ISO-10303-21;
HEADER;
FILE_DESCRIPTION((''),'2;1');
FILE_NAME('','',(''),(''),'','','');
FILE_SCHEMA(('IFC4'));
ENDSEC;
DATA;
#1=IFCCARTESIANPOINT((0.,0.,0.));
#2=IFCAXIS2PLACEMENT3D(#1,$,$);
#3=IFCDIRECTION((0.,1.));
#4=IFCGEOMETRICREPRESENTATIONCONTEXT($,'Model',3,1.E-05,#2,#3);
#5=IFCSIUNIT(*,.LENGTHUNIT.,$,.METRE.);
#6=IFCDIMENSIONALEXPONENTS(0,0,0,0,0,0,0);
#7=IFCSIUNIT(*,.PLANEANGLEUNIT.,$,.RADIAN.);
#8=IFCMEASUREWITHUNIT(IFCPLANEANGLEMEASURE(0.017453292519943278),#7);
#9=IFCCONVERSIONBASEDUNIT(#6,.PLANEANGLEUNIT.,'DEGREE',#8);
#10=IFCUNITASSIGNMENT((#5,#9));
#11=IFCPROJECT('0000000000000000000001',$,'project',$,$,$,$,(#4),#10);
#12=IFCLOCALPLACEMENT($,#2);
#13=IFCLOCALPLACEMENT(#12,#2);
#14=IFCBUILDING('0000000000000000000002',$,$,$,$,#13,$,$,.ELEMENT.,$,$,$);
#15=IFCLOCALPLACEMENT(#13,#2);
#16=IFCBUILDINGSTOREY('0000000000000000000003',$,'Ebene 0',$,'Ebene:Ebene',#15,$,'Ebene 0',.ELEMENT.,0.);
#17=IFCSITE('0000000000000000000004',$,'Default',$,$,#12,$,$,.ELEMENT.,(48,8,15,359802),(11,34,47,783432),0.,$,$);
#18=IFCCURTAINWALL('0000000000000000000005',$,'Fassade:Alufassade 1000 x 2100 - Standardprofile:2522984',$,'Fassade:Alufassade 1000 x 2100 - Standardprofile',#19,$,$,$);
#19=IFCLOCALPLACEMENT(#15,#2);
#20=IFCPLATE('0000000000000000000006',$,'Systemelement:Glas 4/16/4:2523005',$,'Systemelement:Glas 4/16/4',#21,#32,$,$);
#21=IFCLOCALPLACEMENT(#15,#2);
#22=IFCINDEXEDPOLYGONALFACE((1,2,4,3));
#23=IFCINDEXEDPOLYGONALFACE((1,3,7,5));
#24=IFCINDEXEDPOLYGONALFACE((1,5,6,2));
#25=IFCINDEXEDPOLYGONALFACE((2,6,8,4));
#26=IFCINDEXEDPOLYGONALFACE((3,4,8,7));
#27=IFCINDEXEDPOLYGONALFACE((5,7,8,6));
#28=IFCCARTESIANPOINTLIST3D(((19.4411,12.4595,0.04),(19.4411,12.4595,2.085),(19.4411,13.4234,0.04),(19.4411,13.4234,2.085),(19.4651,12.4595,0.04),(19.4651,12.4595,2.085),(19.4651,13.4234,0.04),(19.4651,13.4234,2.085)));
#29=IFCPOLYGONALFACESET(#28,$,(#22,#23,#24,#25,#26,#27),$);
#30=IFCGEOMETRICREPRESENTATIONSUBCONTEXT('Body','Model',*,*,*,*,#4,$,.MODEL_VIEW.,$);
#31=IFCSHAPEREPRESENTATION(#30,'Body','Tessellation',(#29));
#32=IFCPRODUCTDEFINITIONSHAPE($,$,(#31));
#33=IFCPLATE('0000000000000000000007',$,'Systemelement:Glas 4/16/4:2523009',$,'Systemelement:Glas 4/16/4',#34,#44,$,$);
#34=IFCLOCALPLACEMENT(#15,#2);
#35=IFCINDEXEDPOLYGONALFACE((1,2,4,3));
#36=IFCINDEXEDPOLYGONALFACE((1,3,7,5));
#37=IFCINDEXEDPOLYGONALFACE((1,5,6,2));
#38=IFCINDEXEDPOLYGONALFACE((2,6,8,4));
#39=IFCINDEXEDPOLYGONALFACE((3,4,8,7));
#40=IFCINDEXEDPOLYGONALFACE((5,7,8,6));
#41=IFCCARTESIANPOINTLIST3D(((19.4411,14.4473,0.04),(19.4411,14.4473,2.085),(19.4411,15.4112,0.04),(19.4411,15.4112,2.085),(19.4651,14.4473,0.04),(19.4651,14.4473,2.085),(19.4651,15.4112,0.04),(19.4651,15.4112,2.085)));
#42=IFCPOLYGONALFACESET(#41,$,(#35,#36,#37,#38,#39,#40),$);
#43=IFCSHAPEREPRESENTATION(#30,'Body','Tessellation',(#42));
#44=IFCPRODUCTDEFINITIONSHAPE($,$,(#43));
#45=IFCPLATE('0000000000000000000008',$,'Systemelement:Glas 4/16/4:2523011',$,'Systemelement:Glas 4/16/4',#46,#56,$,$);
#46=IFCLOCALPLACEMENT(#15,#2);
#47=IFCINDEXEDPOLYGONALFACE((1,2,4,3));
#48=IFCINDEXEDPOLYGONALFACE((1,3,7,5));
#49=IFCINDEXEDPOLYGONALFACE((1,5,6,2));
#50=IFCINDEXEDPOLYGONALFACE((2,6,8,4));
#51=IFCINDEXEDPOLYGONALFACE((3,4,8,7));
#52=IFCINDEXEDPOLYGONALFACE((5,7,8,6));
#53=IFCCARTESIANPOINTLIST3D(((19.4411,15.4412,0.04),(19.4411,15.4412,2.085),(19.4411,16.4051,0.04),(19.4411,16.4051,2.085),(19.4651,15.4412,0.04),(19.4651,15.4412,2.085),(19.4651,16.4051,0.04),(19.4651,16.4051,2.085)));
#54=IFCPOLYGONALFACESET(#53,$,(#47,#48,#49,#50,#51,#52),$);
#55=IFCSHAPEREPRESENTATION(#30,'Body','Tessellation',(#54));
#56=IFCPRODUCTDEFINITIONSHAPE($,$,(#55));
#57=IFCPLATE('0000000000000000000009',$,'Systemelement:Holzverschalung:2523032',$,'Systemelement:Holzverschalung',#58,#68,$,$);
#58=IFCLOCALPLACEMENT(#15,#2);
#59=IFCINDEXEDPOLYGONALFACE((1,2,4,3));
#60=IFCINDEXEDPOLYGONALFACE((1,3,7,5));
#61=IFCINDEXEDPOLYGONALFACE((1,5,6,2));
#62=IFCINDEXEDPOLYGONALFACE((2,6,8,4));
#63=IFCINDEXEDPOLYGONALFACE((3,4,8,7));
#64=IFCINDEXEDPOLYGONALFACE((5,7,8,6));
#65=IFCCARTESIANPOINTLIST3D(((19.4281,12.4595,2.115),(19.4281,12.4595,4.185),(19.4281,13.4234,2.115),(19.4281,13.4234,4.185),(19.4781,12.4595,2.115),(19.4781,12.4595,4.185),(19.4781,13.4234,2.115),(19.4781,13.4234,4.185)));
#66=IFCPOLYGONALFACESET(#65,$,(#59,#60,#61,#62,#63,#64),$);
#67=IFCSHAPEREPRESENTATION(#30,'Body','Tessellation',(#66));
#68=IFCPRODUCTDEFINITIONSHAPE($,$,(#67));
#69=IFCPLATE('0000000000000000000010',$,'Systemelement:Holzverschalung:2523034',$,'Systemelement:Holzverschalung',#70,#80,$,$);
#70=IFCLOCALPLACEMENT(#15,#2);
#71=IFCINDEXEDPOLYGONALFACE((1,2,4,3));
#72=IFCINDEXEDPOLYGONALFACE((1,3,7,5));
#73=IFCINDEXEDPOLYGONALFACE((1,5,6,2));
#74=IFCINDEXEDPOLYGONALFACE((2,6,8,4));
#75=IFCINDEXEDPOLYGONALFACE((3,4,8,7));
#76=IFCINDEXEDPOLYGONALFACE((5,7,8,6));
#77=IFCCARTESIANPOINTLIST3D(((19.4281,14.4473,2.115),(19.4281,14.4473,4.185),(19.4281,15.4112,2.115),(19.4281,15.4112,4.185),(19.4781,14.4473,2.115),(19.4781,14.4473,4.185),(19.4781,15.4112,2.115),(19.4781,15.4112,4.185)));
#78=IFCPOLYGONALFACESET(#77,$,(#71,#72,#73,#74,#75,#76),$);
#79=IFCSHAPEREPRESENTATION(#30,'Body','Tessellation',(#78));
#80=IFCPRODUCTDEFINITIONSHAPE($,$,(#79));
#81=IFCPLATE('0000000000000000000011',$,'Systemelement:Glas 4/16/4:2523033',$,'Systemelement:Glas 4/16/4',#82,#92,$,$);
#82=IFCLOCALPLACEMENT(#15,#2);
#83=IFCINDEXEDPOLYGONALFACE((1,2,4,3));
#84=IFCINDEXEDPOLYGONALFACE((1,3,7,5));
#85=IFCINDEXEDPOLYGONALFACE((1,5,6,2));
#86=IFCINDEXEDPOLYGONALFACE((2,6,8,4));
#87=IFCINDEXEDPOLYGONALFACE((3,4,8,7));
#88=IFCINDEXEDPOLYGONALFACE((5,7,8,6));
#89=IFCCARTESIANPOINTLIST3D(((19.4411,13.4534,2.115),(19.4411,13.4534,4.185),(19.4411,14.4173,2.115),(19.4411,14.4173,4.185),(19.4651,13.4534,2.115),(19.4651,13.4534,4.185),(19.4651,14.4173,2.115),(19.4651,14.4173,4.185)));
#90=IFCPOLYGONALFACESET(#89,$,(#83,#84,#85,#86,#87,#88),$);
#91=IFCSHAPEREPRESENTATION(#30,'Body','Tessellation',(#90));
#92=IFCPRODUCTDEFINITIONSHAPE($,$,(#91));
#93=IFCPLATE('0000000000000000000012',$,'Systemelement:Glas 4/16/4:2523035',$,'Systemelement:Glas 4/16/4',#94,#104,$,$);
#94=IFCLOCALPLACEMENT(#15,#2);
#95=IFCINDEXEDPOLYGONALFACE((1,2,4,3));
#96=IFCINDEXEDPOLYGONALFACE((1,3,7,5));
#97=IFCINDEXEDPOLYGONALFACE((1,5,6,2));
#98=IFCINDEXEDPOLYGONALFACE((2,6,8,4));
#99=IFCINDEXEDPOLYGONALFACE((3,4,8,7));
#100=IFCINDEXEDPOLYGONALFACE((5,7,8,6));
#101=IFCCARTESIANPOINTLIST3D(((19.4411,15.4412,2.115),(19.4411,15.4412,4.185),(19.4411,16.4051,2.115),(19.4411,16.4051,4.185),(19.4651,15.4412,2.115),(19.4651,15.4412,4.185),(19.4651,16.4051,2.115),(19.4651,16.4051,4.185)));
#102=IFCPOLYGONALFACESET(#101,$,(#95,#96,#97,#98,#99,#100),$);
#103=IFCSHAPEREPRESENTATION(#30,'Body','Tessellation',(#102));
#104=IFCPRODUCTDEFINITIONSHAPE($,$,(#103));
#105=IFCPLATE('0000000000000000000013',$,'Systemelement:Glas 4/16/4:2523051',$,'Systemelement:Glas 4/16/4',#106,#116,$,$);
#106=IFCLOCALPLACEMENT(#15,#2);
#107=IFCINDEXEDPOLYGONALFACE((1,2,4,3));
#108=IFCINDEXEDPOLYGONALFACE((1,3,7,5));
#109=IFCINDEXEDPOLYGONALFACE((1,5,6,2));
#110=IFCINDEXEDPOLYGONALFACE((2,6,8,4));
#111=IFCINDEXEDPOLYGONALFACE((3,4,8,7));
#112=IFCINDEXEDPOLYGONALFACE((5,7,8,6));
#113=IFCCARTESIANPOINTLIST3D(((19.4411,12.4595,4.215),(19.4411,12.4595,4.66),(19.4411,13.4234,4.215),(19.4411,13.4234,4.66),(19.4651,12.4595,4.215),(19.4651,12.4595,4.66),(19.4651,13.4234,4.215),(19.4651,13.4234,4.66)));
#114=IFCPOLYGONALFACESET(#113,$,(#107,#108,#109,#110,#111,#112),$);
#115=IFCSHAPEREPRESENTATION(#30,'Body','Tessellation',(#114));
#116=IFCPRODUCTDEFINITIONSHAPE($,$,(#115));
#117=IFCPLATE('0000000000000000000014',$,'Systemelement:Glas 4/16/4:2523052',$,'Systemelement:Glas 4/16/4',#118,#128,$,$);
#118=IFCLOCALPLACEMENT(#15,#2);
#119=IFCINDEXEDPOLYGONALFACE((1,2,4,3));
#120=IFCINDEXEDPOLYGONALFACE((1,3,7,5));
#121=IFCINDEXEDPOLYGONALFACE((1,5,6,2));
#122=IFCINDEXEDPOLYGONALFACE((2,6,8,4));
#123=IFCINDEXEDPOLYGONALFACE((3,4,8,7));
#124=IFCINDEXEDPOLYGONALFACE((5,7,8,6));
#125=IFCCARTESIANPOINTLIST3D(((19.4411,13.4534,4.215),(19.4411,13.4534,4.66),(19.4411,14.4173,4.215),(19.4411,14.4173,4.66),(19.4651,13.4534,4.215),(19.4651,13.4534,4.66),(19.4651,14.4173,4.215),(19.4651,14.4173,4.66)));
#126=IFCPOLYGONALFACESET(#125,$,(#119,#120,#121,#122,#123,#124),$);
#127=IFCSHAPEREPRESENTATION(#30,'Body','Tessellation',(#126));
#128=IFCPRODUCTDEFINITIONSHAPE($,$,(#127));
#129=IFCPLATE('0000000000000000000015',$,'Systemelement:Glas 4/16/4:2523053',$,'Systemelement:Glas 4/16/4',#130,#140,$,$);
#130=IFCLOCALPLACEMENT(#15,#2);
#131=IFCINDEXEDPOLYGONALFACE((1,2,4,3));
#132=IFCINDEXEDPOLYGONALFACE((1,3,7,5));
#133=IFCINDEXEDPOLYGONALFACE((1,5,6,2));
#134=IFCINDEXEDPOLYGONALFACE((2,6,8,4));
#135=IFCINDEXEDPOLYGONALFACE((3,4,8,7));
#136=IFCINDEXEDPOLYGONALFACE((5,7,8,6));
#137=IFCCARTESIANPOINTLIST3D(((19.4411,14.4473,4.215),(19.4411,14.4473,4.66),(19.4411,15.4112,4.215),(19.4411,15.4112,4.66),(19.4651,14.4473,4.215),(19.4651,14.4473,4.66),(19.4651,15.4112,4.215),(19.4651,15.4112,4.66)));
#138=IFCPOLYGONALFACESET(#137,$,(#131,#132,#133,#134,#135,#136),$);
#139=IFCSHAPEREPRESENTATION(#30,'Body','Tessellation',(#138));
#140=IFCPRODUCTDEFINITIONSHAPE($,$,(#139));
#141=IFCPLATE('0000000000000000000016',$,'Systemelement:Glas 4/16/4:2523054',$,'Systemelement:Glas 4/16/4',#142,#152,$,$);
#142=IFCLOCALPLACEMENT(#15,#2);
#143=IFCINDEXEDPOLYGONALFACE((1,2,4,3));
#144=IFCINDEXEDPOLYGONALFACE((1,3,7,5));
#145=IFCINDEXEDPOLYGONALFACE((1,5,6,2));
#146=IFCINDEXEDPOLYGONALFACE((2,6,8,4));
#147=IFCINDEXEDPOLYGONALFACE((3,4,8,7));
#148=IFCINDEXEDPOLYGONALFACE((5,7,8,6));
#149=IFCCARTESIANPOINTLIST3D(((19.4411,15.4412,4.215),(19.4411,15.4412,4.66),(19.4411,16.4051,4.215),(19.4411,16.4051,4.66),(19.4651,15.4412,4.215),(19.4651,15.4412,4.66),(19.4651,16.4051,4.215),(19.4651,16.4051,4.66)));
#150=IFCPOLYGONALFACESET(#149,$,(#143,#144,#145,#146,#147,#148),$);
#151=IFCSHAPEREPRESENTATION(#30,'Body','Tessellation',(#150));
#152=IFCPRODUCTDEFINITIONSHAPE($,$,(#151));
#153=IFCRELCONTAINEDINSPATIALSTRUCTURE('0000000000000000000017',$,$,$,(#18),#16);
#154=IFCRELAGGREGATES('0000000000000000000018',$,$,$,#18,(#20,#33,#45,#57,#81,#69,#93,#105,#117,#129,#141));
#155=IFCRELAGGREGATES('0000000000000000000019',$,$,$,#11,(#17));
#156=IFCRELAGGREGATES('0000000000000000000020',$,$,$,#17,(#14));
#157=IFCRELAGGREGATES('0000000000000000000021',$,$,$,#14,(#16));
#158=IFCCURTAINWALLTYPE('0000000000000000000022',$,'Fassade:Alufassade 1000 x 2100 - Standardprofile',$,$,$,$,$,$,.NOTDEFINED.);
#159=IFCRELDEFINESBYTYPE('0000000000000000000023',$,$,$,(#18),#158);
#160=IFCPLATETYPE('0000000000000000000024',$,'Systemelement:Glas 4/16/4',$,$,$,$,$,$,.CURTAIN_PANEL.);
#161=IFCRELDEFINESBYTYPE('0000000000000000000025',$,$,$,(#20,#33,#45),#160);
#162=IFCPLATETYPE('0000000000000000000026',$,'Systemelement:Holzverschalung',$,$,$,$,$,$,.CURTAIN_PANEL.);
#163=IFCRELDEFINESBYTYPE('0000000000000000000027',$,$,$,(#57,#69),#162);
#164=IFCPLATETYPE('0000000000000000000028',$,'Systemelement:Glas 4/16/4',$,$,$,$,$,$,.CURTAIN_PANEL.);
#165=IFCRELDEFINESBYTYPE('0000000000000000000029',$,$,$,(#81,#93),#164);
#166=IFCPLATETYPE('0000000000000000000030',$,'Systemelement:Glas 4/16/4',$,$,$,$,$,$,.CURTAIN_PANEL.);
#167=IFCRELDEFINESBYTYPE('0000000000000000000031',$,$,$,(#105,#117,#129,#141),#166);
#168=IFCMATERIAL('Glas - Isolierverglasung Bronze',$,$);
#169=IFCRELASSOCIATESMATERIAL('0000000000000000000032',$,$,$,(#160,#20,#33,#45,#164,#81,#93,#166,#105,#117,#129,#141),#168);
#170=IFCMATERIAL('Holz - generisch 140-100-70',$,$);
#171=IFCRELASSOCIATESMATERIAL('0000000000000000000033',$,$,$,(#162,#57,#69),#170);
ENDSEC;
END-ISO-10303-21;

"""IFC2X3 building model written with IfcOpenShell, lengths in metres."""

from ifc_helpers import new_model, entity, si_unit, converted_unit, direction, frame, origin, origin_2d_with_axis, place, context, subcontext, project, spatial, rectangle, extrude, source, transform, mapped, material, type_object, type_shapes, element, aggregate, save


model = new_model("IFC2X3")

# Units and contexts
model_context = context("Model", 3, precision=1e-05, world=origin(), true_north=direction((0.0, 1.0)))
body_context = subcontext(model_context, "Body", "Model", "MODEL_VIEW")
ifc_project = project(units=[si_unit("LENGTHUNIT", "METRE"), converted_unit("PLANEANGLEUNIT", "DEGREE", entity("IfcPlaneAngleMeasure", 0.017453292519943278), si_unit("PLANEANGLEUNIT", "RADIAN"), dimensions=[0, 0, 0, 0, 0, 0, 0])], contexts=[model_context])

# Site, building, storey
site_placement = place(None, origin())
site = spatial("IfcSite", under=ifc_project, at=site_placement, Name="Default", CompositionType="ELEMENT", RefLatitude=(48, 8, 15, 359802), RefLongitude=(11, 34, 47, 783432), RefElevation=0.0)
building_placement = place(site_placement, origin())
building = spatial("IfcBuilding", under=site, at=building_placement, CompositionType="ELEMENT")
storey_placement = place(building_placement, origin())
storey = spatial("IfcBuildingStorey", under=building, at=storey_placement, Name="Ebene 0", ObjectType="Ebene:Ebene", LongName="Ebene 0", CompositionType="ELEMENT", Elevation=0.0)

# Curtain wall, plates
curtain_wall_type = type_object("IfcCurtainWallType", Name="Fassade:Alufassade 1000 x 2100 - Standardprofile", PredefinedType="NOTDEFINED")
curtain_wall_placement = place(storey_placement, origin())
curtain_wall = element("IfcCurtainWall", 1, at=curtain_wall_placement, inside=storey, type_object=curtain_wall_type, Name="Fassade:Alufassade 1000 x 2100 - Standardprofile:2522984", ObjectType="Fassade:Alufassade 1000 x 2100 - Standardprofile")
ifc_material_1 = material(Name="Glas - Isolierverglasung Bronze")
plate_type_1 = type_object("IfcPlateType", Name="Systemelement:Glas 4/16/4", PredefinedType="CURTAIN_PANEL", material=ifc_material_1)
shared_shape_1 = source(origin(), body_context, "Body", "SweptSolid", [
    extrude(rectangle(XDim=0.024, YDim=0.9639, at=origin_2d_with_axis()), frame((0.0, 0.0, 0.0), z_axis=(0.0, 0.0, 1.0), x_axis=(0.0, 1.0, 0.0)), (0.0, 0.0, 1.0), 2.045),
])
type_shapes(plate_type_1, [shared_shape_1])
plate_1_placement = place(curtain_wall_placement, frame((19.4531, 12.9414, 0.04), z_axis=(0.0, 0.0, 1.0), x_axis=(0.0, 1.0, 0.0)))
plate_1 = element("IfcPlate", 2, at=plate_1_placement, type_object=plate_type_1, material=ifc_material_1, Name="Systemelement:Glas 4/16/4:2523005", ObjectType="Systemelement:Glas 4/16/4", context=body_context, shape_type="MappedRepresentation", body=[
    mapped(shared_shape_1, transform((0.0, 0.0, 0.0), scale=1.0)),
])
plate_2_placement = place(curtain_wall_placement, frame((19.4531, 14.9292, 0.04), z_axis=(0.0, 0.0, 1.0), x_axis=(0.0, 1.0, 0.0)))
plate_2 = element("IfcPlate", 3, at=plate_2_placement, type_object=plate_type_1, material=ifc_material_1, Name="Systemelement:Glas 4/16/4:2523009", ObjectType="Systemelement:Glas 4/16/4", context=body_context, shape_type="MappedRepresentation", body=[
    mapped(shared_shape_1, transform((0.0, 0.0, 0.0), scale=1.0)),
])
plate_3_placement = place(curtain_wall_placement, frame((19.4531, 15.9231, 0.04), z_axis=(0.0, 0.0, 1.0), x_axis=(0.0, 1.0, 0.0)))
plate_3 = element("IfcPlate", 4, at=plate_3_placement, type_object=plate_type_1, material=ifc_material_1, Name="Systemelement:Glas 4/16/4:2523011", ObjectType="Systemelement:Glas 4/16/4", context=body_context, shape_type="MappedRepresentation", body=[
    mapped(shared_shape_1, transform((0.0, 0.0, 0.0), scale=1.0)),
])
ifc_material_2 = material(Name="Holz - generisch 140-100-70")
plate_type_2 = type_object("IfcPlateType", Name="Systemelement:Holzverschalung", PredefinedType="CURTAIN_PANEL", material=ifc_material_2)
shared_shape_2 = source(origin(), body_context, "Body", "SweptSolid", [
    extrude(rectangle(XDim=0.05, YDim=0.9639, at=origin_2d_with_axis()), frame((0.0, 0.0, 0.0), z_axis=(0.0, 0.0, 1.0), x_axis=(0.0, 1.0, 0.0)), (0.0, 0.0, 1.0), 2.07),
])
type_shapes(plate_type_2, [shared_shape_2])
plate_4_placement = place(curtain_wall_placement, frame((19.4531, 12.9414, 2.115), z_axis=(0.0, 0.0, 1.0), x_axis=(0.0, 1.0, 0.0)))
plate_4 = element("IfcPlate", 5, at=plate_4_placement, type_object=plate_type_2, material=ifc_material_2, Name="Systemelement:Holzverschalung:2523032", ObjectType="Systemelement:Holzverschalung", context=body_context, shape_type="MappedRepresentation", body=[
    mapped(shared_shape_2, transform((0.0, 0.0, 0.0), scale=1.0)),
])
plate_5_placement = place(curtain_wall_placement, frame((19.4531, 14.9292, 2.115), z_axis=(0.0, 0.0, 1.0), x_axis=(0.0, 1.0, 0.0)))
plate_5 = element("IfcPlate", 6, at=plate_5_placement, type_object=plate_type_2, material=ifc_material_2, Name="Systemelement:Holzverschalung:2523034", ObjectType="Systemelement:Holzverschalung", context=body_context, shape_type="MappedRepresentation", body=[
    mapped(shared_shape_2, transform((0.0, 0.0, 0.0), scale=1.0)),
])
plate_type_3 = type_object("IfcPlateType", Name="Systemelement:Glas 4/16/4", PredefinedType="CURTAIN_PANEL", material=ifc_material_1)
shared_shape_3 = source(origin(), body_context, "Body", "SweptSolid", [
    extrude(rectangle(XDim=0.024, YDim=0.9639, at=origin_2d_with_axis()), frame((0.0, 0.0, 0.0), z_axis=(0.0, 0.0, 1.0), x_axis=(0.0, 1.0, 0.0)), (0.0, 0.0, 1.0), 2.07),
])
type_shapes(plate_type_3, [shared_shape_3])
plate_6_placement = place(curtain_wall_placement, frame((19.4531, 13.9353, 2.115), z_axis=(0.0, 0.0, 1.0), x_axis=(0.0, 1.0, 0.0)))
plate_6 = element("IfcPlate", 7, at=plate_6_placement, type_object=plate_type_3, material=ifc_material_1, Name="Systemelement:Glas 4/16/4:2523033", ObjectType="Systemelement:Glas 4/16/4", context=body_context, shape_type="MappedRepresentation", body=[
    mapped(shared_shape_3, transform((0.0, 0.0, 0.0), scale=1.0)),
])
plate_7_placement = place(curtain_wall_placement, frame((19.4531, 15.9231, 2.115), z_axis=(0.0, 0.0, 1.0), x_axis=(0.0, 1.0, 0.0)))
plate_7 = element("IfcPlate", 8, at=plate_7_placement, type_object=plate_type_3, material=ifc_material_1, Name="Systemelement:Glas 4/16/4:2523035", ObjectType="Systemelement:Glas 4/16/4", context=body_context, shape_type="MappedRepresentation", body=[
    mapped(shared_shape_3, transform((0.0, 0.0, 0.0), scale=1.0)),
])
plate_type_4 = type_object("IfcPlateType", Name="Systemelement:Glas 4/16/4", PredefinedType="CURTAIN_PANEL", material=ifc_material_1)
shared_shape_4 = source(origin(), body_context, "Body", "SweptSolid", [
    extrude(rectangle(XDim=0.024, YDim=0.9639, at=origin_2d_with_axis()), frame((0.0, 0.0, 0.0), z_axis=(0.0, 0.0, 1.0), x_axis=(0.0, 1.0, 0.0)), (0.0, 0.0, 1.0), 0.445),
])
type_shapes(plate_type_4, [shared_shape_4])
plate_8_placement = place(curtain_wall_placement, frame((19.4531, 12.9414, 4.215), z_axis=(0.0, 0.0, 1.0), x_axis=(0.0, 1.0, 0.0)))
plate_8 = element("IfcPlate", 9, at=plate_8_placement, type_object=plate_type_4, material=ifc_material_1, Name="Systemelement:Glas 4/16/4:2523051", ObjectType="Systemelement:Glas 4/16/4", context=body_context, shape_type="MappedRepresentation", body=[
    mapped(shared_shape_4, transform((0.0, 0.0, 0.0), scale=1.0)),
])
plate_9_placement = place(curtain_wall_placement, frame((19.4531, 13.9353, 4.215), z_axis=(0.0, 0.0, 1.0), x_axis=(0.0, 1.0, 0.0)))
plate_9 = element("IfcPlate", 10, at=plate_9_placement, type_object=plate_type_4, material=ifc_material_1, Name="Systemelement:Glas 4/16/4:2523052", ObjectType="Systemelement:Glas 4/16/4", context=body_context, shape_type="MappedRepresentation", body=[
    mapped(shared_shape_4, transform((0.0, 0.0, 0.0), scale=1.0)),
])
plate_10_placement = place(curtain_wall_placement, frame((19.4531, 14.9292, 4.215), z_axis=(0.0, 0.0, 1.0), x_axis=(0.0, 1.0, 0.0)))
plate_10 = element("IfcPlate", 11, at=plate_10_placement, type_object=plate_type_4, material=ifc_material_1, Name="Systemelement:Glas 4/16/4:2523053", ObjectType="Systemelement:Glas 4/16/4", context=body_context, shape_type="MappedRepresentation", body=[
    mapped(shared_shape_4, transform((0.0, 0.0, 0.0), scale=1.0)),
])
plate_11_placement = place(curtain_wall_placement, frame((19.4531, 15.9231, 4.215), z_axis=(0.0, 0.0, 1.0), x_axis=(0.0, 1.0, 0.0)))
plate_11 = element("IfcPlate", 12, at=plate_11_placement, type_object=plate_type_4, material=ifc_material_1, Name="Systemelement:Glas 4/16/4:2523054", ObjectType="Systemelement:Glas 4/16/4", context=body_context, shape_type="MappedRepresentation", body=[
    mapped(shared_shape_4, transform((0.0, 0.0, 0.0), scale=1.0)),
])
aggregate(curtain_wall, [plate_1, plate_2, plate_3, plate_4, plate_6, plate_5, plate_7, plate_8, plate_9, plate_10, plate_11])

save(model, "model.ifc")
